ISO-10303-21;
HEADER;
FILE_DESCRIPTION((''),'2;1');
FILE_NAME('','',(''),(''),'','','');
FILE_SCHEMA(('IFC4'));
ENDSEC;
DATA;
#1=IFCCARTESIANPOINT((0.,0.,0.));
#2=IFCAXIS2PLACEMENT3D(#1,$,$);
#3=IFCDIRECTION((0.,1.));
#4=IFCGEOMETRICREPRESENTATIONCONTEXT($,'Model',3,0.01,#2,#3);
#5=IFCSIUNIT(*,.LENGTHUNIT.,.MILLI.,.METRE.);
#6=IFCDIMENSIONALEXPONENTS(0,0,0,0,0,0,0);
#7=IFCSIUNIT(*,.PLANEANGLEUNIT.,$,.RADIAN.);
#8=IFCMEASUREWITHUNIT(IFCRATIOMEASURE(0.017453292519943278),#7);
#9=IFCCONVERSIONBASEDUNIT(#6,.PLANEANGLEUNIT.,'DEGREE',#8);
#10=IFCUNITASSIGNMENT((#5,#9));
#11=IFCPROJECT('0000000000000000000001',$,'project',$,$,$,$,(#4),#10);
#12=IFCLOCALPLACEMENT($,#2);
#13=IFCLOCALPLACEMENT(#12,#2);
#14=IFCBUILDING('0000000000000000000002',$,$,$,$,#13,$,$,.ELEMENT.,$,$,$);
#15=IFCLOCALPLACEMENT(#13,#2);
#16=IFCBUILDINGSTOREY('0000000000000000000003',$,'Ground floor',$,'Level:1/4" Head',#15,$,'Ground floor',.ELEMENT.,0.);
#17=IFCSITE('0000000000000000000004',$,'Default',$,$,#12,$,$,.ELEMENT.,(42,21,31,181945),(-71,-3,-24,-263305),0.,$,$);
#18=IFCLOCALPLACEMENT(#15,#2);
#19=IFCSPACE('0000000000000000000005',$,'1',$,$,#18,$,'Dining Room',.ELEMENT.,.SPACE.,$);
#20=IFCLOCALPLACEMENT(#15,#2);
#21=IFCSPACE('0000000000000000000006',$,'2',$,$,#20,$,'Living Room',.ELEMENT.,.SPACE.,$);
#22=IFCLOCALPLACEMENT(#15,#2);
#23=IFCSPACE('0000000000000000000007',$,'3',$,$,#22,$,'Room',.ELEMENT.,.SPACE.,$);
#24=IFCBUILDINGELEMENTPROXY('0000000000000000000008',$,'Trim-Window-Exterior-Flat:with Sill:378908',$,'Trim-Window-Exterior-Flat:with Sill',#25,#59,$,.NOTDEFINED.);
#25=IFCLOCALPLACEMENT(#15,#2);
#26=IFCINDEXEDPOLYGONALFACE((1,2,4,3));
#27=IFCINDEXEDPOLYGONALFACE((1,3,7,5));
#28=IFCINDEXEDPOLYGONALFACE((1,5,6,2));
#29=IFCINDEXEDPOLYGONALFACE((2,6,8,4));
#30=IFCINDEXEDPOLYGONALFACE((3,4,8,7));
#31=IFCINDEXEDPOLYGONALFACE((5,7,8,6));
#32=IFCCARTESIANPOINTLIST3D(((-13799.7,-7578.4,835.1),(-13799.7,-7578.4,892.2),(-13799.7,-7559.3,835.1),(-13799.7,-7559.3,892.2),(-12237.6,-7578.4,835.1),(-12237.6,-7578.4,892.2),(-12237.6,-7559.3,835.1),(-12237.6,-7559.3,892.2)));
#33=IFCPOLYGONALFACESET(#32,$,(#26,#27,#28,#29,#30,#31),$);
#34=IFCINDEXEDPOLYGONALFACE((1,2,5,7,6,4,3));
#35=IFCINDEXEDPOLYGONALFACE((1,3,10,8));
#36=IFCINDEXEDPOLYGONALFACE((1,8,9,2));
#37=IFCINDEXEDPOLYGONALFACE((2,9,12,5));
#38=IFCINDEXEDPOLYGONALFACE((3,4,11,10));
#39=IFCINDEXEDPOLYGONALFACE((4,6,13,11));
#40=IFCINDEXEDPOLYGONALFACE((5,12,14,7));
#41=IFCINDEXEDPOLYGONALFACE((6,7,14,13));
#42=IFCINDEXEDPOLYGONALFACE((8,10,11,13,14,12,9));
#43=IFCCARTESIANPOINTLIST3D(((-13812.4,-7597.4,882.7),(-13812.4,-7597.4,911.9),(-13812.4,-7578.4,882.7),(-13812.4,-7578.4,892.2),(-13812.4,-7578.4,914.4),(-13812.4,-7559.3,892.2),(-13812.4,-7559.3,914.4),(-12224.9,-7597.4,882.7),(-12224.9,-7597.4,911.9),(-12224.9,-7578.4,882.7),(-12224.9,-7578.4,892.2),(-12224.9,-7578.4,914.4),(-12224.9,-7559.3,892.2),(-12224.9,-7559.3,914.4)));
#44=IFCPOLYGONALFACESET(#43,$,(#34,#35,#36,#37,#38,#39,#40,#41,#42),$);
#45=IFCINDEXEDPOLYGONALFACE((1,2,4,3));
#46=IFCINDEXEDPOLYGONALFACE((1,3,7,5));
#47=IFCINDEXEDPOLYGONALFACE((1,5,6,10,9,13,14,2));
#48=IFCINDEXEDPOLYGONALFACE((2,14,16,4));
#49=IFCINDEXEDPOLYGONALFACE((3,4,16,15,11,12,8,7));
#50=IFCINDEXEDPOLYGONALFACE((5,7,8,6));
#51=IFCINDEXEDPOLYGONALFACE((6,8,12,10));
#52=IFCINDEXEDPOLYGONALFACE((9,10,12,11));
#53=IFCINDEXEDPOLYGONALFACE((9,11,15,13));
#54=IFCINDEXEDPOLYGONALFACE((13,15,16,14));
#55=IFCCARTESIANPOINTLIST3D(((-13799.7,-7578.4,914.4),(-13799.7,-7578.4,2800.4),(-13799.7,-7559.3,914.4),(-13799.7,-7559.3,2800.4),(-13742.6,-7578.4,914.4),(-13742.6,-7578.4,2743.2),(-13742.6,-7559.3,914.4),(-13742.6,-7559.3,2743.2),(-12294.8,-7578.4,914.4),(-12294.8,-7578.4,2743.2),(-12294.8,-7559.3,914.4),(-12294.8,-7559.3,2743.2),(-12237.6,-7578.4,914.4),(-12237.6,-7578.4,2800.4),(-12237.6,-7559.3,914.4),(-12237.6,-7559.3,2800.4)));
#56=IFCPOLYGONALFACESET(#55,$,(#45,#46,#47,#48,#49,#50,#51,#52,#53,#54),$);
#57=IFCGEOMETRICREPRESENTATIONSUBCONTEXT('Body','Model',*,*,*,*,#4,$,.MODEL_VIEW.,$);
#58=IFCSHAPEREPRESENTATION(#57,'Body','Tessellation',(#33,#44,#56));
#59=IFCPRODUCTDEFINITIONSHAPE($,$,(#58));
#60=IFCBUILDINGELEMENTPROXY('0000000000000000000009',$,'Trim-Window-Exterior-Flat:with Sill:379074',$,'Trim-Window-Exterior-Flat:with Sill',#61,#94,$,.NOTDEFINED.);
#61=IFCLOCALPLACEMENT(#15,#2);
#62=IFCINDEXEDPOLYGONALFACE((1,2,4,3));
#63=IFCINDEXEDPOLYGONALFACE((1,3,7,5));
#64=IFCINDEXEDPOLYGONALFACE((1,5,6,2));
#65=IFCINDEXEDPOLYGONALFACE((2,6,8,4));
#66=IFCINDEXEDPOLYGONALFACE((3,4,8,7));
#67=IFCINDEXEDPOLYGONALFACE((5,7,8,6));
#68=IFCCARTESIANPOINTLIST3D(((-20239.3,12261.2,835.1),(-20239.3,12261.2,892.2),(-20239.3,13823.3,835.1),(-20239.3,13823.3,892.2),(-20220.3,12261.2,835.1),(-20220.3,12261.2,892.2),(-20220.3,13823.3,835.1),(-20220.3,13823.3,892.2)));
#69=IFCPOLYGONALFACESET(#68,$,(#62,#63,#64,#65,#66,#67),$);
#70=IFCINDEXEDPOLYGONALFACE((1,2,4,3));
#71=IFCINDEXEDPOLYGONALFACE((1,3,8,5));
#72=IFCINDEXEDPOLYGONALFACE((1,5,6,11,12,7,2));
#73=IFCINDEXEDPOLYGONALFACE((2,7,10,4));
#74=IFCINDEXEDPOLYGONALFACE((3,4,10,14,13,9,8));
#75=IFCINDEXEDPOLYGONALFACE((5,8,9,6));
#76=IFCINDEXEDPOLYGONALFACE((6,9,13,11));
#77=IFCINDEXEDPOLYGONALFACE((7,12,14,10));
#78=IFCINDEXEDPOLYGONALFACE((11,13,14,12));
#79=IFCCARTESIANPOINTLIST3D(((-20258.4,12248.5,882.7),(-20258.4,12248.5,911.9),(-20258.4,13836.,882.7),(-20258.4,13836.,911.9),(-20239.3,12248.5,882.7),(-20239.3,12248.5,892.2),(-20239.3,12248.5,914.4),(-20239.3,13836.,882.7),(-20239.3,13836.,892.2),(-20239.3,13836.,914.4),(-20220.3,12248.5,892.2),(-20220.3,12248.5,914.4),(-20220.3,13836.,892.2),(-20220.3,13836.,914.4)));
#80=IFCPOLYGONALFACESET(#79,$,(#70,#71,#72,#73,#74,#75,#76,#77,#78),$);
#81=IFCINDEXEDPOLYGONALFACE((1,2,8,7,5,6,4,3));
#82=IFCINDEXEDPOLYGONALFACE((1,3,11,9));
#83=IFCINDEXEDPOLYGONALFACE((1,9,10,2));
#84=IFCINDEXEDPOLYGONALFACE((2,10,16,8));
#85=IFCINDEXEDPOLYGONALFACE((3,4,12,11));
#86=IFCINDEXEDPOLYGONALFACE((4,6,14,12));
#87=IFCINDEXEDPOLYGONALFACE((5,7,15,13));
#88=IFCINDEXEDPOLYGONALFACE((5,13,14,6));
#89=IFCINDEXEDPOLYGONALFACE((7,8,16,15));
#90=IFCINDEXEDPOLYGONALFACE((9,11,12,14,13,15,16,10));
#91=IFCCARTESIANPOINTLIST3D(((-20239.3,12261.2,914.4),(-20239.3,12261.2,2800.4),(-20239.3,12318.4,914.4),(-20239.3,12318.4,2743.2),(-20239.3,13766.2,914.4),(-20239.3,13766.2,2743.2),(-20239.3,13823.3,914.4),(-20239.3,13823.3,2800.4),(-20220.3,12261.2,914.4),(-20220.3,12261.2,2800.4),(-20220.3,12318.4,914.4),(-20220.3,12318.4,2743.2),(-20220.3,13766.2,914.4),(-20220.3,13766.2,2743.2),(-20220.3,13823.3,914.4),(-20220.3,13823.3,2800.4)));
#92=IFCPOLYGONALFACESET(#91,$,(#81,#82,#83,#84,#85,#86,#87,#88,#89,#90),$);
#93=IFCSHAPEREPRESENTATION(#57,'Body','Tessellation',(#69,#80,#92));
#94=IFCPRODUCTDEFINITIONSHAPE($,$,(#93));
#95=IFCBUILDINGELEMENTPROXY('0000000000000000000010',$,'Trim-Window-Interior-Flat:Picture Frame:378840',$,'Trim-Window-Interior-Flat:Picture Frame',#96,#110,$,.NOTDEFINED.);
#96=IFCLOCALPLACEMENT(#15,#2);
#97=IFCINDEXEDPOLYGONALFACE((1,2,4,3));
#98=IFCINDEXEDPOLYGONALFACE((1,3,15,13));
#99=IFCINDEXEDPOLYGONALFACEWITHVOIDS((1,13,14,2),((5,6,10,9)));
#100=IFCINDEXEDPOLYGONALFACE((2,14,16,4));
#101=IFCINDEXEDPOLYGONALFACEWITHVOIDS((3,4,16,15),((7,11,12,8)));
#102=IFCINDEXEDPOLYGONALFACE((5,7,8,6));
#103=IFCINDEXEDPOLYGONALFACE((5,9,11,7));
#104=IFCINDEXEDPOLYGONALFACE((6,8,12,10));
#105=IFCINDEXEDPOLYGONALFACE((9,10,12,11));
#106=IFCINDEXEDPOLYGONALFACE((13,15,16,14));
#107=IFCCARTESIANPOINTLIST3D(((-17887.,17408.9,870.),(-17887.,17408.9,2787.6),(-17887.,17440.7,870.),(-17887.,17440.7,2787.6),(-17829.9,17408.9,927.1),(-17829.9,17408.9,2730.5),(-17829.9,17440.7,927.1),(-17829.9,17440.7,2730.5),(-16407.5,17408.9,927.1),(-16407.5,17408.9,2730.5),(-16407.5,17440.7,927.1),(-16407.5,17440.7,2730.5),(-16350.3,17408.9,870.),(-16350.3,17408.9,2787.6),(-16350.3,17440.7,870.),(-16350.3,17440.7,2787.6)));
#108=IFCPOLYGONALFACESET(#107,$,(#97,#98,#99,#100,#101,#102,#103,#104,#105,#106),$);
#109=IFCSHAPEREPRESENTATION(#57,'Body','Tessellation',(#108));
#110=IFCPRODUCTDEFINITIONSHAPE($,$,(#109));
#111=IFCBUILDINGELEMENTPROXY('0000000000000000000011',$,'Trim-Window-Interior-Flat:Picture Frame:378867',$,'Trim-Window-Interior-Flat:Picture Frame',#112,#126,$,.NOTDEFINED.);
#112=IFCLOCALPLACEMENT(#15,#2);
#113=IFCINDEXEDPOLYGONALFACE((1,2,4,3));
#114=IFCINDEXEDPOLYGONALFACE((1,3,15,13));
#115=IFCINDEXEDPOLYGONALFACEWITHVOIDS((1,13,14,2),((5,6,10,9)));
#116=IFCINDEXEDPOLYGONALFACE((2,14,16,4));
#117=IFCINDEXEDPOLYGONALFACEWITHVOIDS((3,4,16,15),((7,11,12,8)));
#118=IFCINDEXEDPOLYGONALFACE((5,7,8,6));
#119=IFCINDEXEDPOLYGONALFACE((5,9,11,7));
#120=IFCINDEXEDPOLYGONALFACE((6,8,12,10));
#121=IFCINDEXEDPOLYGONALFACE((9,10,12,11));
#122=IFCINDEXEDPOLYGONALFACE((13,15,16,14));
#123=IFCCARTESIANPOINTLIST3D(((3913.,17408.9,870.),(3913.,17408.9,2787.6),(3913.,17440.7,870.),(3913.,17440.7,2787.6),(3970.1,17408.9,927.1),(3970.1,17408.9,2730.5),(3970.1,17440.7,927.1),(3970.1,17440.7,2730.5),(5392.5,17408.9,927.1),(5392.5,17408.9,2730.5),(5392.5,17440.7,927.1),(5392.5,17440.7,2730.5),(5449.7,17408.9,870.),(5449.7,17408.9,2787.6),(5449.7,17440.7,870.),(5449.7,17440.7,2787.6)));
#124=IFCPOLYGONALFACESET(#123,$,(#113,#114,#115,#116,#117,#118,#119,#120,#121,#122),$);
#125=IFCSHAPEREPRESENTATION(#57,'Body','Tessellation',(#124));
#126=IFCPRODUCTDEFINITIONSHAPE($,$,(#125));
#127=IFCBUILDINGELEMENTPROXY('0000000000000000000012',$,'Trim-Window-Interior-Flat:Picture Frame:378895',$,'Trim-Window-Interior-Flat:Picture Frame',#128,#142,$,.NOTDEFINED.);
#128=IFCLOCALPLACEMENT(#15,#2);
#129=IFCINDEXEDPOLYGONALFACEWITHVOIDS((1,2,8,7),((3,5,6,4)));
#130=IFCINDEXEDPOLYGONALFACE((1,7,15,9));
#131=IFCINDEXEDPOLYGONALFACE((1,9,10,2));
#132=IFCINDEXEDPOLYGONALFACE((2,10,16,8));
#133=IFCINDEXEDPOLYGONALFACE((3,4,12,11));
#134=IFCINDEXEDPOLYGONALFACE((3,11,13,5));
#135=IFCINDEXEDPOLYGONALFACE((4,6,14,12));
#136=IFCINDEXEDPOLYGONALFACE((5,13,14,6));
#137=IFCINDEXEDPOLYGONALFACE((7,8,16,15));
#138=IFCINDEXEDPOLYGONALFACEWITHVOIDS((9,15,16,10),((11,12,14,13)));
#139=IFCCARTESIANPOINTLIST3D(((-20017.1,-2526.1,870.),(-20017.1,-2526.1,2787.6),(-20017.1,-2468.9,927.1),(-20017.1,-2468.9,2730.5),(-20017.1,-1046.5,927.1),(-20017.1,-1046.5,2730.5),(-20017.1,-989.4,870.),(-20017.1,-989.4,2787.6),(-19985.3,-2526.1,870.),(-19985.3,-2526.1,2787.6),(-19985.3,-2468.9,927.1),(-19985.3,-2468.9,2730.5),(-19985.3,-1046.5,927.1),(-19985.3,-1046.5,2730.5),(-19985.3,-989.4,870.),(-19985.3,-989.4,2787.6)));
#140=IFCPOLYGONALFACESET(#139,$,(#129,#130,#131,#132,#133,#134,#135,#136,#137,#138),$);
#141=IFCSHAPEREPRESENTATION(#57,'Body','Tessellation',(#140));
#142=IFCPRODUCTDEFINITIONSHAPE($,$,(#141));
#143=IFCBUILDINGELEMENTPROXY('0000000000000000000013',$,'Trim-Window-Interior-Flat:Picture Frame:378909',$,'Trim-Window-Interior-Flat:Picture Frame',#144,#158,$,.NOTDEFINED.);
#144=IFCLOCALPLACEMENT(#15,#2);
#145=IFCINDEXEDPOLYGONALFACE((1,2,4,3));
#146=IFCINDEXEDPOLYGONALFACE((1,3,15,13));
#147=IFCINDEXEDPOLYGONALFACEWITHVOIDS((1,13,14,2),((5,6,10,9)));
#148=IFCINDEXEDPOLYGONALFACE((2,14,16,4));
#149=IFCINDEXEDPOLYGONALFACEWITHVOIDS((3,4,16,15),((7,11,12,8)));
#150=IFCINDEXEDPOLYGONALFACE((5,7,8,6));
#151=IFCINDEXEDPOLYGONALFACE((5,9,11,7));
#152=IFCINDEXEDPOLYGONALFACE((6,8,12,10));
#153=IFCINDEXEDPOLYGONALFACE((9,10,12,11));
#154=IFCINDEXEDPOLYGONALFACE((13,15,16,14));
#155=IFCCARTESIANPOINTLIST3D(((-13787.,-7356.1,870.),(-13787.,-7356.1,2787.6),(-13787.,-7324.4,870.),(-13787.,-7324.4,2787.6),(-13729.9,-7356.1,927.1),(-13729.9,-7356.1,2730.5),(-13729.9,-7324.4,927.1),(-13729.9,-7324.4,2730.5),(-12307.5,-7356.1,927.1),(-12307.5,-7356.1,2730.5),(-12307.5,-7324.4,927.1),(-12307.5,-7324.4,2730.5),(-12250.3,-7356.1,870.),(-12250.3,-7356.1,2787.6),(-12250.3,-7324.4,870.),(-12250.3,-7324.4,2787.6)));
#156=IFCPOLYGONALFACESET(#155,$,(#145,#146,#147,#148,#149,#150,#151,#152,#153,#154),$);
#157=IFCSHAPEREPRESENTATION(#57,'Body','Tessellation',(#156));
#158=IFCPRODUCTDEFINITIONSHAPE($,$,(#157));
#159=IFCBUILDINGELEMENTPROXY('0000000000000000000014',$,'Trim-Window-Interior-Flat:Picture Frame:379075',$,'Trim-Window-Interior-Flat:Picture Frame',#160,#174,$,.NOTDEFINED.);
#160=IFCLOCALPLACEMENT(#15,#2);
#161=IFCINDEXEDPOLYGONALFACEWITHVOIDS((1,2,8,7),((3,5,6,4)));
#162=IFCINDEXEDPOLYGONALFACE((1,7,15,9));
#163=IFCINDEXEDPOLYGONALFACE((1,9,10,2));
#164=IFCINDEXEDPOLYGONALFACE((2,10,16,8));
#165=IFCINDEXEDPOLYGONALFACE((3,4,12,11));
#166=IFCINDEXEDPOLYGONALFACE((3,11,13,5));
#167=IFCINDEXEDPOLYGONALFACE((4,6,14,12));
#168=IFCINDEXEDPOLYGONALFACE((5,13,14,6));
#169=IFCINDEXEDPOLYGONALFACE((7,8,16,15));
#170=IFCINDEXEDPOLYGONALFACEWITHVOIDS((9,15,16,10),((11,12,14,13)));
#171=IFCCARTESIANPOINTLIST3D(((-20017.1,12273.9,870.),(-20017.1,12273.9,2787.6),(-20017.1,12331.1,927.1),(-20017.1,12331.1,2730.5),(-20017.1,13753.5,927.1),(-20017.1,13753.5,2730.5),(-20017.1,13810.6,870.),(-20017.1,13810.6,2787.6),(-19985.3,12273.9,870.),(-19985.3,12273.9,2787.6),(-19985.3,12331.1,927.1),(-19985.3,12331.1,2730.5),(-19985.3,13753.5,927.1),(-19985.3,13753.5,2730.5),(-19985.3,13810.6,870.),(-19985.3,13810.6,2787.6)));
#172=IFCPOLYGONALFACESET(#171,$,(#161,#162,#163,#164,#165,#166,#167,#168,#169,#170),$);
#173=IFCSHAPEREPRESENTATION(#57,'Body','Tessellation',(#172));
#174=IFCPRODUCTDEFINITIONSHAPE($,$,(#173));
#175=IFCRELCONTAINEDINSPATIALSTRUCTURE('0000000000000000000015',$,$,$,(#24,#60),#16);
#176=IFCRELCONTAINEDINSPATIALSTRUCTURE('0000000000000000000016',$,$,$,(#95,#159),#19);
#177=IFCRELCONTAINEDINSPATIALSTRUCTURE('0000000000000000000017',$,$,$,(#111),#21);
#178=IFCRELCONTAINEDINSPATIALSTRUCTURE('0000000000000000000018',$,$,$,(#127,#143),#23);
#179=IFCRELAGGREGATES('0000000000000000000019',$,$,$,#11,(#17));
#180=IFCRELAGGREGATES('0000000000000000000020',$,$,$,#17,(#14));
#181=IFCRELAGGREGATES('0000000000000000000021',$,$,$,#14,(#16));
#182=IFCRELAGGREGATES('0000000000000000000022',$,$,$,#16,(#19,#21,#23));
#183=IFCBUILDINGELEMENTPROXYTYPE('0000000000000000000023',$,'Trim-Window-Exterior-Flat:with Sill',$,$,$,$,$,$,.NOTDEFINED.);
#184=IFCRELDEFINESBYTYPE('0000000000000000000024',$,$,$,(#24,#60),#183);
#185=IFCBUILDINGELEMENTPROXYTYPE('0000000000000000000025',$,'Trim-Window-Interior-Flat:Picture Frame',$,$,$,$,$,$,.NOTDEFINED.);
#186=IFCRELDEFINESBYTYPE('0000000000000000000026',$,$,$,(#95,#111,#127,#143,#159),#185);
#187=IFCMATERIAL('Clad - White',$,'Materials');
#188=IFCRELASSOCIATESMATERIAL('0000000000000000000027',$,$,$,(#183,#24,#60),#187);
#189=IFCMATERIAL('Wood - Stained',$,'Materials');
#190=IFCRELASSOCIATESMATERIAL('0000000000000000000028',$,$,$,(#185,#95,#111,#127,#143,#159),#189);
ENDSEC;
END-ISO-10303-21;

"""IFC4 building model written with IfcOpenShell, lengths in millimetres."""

from ifc_helpers import new_model, entity, si_unit, converted_unit, direction, frame, origin, place, context, subcontext, project, spatial, indexed_curve, outline, extrude, source, transform, mapped, material, type_object, type_shapes, element, save


model = new_model("IFC4")

# Units and contexts
model_context = context("Model", 3, precision=0.01, world=origin(), true_north=direction((0.0, 1.0)))
body_context = subcontext(model_context, "Body", "Model", "MODEL_VIEW")
ifc_project = project(units=[si_unit("LENGTHUNIT", "METRE", prefix="MILLI"), converted_unit("PLANEANGLEUNIT", "DEGREE", entity("IfcRatioMeasure", 0.017453292519943278), si_unit("PLANEANGLEUNIT", "RADIAN"), dimensions=[0, 0, 0, 0, 0, 0, 0])], contexts=[model_context])

# Site, building, storey
site_placement = place(None, origin())
site = spatial("IfcSite", under=ifc_project, at=site_placement, Name="Default", CompositionType="ELEMENT", RefLatitude=(42, 21, 31, 181945), RefLongitude=(-71, -3, -24, -263305), RefElevation=0.0)
building_placement = place(site_placement, origin())
building = spatial("IfcBuilding", under=site, at=building_placement, CompositionType="ELEMENT")
storey_placement = place(building_placement, origin())
storey = spatial("IfcBuildingStorey", under=building, at=storey_placement, Name="Ground floor", ObjectType="Level:1/4\" Head", LongName="Ground floor", CompositionType="ELEMENT", Elevation=0.0)

# Building element proxies
ifc_material_1 = material(Name="Clad - White", Category="Materials")
ifc_material_2 = material(Name="Wood - Stained", Category="Materials")
building_element_proxy_type_1 = type_object("IfcBuildingElementProxyType", Name="Trim-Window-Exterior-Flat:with Sill", PredefinedType="NOTDEFINED", material=ifc_material_1)
shared_shape_1 = source(origin(), body_context, "Body", "SweptSolid", [
    extrude(outline(indexed_curve([(-781.0, -28.6), (781.0, -28.6), (781.0, 28.6), (-781.0, 28.6), (-781.0, -28.6)], self_intersect=False)), frame((0.0, -1879.6, 0.0), z_axis=(0.0, 0.0, 1.0), x_axis=(-1.0, 0.0, 0.0)), (0.0, 0.0, 1.0), 19.0),
    extrude(outline(indexed_curve([(-19.0, -16.0), (0.0, -16.0), (0.0, -6.4), (19.0, -6.4), (19.0, 15.8), (0.0, 15.8), (-19.0, 13.3), (-19.0, -16.0)], self_intersect=False)), frame((-793.7, -1844.6, 19.0), z_axis=(1.0, 0.0, 0.0), x_axis=(0.0, 0.0, -1.0)), (0.0, 0.0, 1.0), 1587.5),
    extrude(outline(indexed_curve([(-957.3, -781.0), (928.7, -781.0), (928.7, -723.9), (-900.1, -723.9), (-900.1, 723.9), (928.7, 723.9), (928.7, 781.0), (-957.3, 781.0), (-957.3, -781.0)], self_intersect=False)), frame((0.0, -900.1, 0.0), z_axis=(0.0, 0.0, 1.0), x_axis=(0.0, -1.0, 0.0)), (0.0, 0.0, 1.0), 19.0),
])
type_shapes(building_element_proxy_type_1, [shared_shape_1])
for number, where, z_axis, x_axis, name in (
    (1, (-13018.7, -7559.3, 2743.2), (0.0, -1.0, 0.0), (1.0, 0.0, 0.0), "Trim-Window-Exterior-Flat:with Sill:378908"),
    (2, (-20220.3, 13042.3, 2743.2), (-1.0, 0.0, 0.0), (0.0, -1.0, 0.0), "Trim-Window-Exterior-Flat:with Sill:379074"),
):
    element("IfcBuildingElementProxy", number, at=place(storey_placement, frame(where, z_axis=z_axis, x_axis=x_axis)), inside=storey, type_object=building_element_proxy_type_1, material=ifc_material_1, Name=name, ObjectType="Trim-Window-Exterior-Flat:with Sill", PredefinedType="NOTDEFINED", context=body_context, shape_type="MappedRepresentation", body=[
        mapped(shared_shape_1, transform((0.0, 0.0, 0.0), scale=1.0)),
    ])

# Shared definitions
space_1_placement = place(storey_placement, origin())
space_1 = spatial("IfcSpace", under=storey, at=space_1_placement, Name="1", LongName="Dining Room", CompositionType="ELEMENT", PredefinedType="SPACE")

# Building element proxy
building_element_proxy_type_2 = type_object("IfcBuildingElementProxyType", Name="Trim-Window-Interior-Flat:Picture Frame", PredefinedType="NOTDEFINED", material=ifc_material_2)
shared_shape_2 = source(origin(), body_context, "Body", "SweptSolid", [
    extrude(outline(indexed_curve([(-768.3, -958.8), (768.3, -958.8), (768.3, 958.8), (-768.3, 958.8), (-768.3, -958.8)], self_intersect=False), holes=[indexed_curve([(-711.2, -901.7), (-711.2, 901.7), (711.2, 901.7), (711.2, -901.7), (-711.2, -901.7)], self_intersect=False)]), frame((0.0, -914.4, 0.0), z_axis=(0.0, 0.0, 1.0), x_axis=(-1.0, 0.0, 0.0)), (0.0, 0.0, 1.0), 31.7),
])
type_shapes(building_element_proxy_type_2, [shared_shape_2])
proxy_1_placement = place(space_1_placement, frame((-17118.7, 17440.7, 2743.2), z_axis=(0.0, -1.0, 0.0), x_axis=(1.0, 0.0, 0.0)))
element("IfcBuildingElementProxy", 3, at=proxy_1_placement, inside=space_1, type_object=building_element_proxy_type_2, material=ifc_material_2, Name="Trim-Window-Interior-Flat:Picture Frame:378840", ObjectType="Trim-Window-Interior-Flat:Picture Frame", PredefinedType="NOTDEFINED", context=body_context, shape_type="MappedRepresentation", body=[
    mapped(shared_shape_2, transform((0.0, 0.0, 0.0), scale=1.0)),
])

# Shared definitions
space_2_placement = place(storey_placement, origin())
space_2 = spatial("IfcSpace", under=storey, at=space_2_placement, Name="2", LongName="Living Room", CompositionType="ELEMENT", PredefinedType="SPACE")

# Building element proxy
proxy_2_placement = place(space_2_placement, frame((4681.3, 17440.7, 2743.2), z_axis=(0.0, -1.0, 0.0), x_axis=(1.0, 0.0, 0.0)))
element("IfcBuildingElementProxy", 4, at=proxy_2_placement, inside=space_2, type_object=building_element_proxy_type_2, material=ifc_material_2, Name="Trim-Window-Interior-Flat:Picture Frame:378867", ObjectType="Trim-Window-Interior-Flat:Picture Frame", PredefinedType="NOTDEFINED", context=body_context, shape_type="MappedRepresentation", body=[
    mapped(shared_shape_2, transform((0.0, 0.0, 0.0), scale=1.0)),
])

# Shared definitions
space_3_placement = place(storey_placement, origin())
space_3 = spatial("IfcSpace", under=storey, at=space_3_placement, Name="3", LongName="Room", CompositionType="ELEMENT", PredefinedType="SPACE")

# Building element proxies
for number, where, z_axis, x_axis, name in (
    (5, (-20017.1, -1757.7, 2743.2), (1.0, 0.0, 0.0), (0.0, 1.0, 0.0), "Trim-Window-Interior-Flat:Picture Frame:378895"),
    (6, (-13018.7, -7356.1, 2743.2), (0.0, 1.0, 0.0), (-1.0, 0.0, 0.0), "Trim-Window-Interior-Flat:Picture Frame:378909"),
):
    element("IfcBuildingElementProxy", number, at=place(space_3_placement, frame(where, z_axis=z_axis, x_axis=x_axis)), inside=space_3, type_object=building_element_proxy_type_2, material=ifc_material_2, Name=name, ObjectType="Trim-Window-Interior-Flat:Picture Frame", PredefinedType="NOTDEFINED", context=body_context, shape_type="MappedRepresentation", body=[
        mapped(shared_shape_2, transform((0.0, 0.0, 0.0), scale=1.0)),
    ])
proxy_3_placement = place(space_1_placement, frame((-20017.1, 13042.3, 2743.2), z_axis=(1.0, 0.0, 0.0), x_axis=(0.0, 1.0, 0.0)))
element("IfcBuildingElementProxy", 7, at=proxy_3_placement, inside=space_1, type_object=building_element_proxy_type_2, material=ifc_material_2, Name="Trim-Window-Interior-Flat:Picture Frame:379075", ObjectType="Trim-Window-Interior-Flat:Picture Frame", PredefinedType="NOTDEFINED", context=body_context, shape_type="MappedRepresentation", body=[
    mapped(shared_shape_2, transform((0.0, 0.0, 0.0), scale=1.0)),
])

save(model, "model.ifc")
